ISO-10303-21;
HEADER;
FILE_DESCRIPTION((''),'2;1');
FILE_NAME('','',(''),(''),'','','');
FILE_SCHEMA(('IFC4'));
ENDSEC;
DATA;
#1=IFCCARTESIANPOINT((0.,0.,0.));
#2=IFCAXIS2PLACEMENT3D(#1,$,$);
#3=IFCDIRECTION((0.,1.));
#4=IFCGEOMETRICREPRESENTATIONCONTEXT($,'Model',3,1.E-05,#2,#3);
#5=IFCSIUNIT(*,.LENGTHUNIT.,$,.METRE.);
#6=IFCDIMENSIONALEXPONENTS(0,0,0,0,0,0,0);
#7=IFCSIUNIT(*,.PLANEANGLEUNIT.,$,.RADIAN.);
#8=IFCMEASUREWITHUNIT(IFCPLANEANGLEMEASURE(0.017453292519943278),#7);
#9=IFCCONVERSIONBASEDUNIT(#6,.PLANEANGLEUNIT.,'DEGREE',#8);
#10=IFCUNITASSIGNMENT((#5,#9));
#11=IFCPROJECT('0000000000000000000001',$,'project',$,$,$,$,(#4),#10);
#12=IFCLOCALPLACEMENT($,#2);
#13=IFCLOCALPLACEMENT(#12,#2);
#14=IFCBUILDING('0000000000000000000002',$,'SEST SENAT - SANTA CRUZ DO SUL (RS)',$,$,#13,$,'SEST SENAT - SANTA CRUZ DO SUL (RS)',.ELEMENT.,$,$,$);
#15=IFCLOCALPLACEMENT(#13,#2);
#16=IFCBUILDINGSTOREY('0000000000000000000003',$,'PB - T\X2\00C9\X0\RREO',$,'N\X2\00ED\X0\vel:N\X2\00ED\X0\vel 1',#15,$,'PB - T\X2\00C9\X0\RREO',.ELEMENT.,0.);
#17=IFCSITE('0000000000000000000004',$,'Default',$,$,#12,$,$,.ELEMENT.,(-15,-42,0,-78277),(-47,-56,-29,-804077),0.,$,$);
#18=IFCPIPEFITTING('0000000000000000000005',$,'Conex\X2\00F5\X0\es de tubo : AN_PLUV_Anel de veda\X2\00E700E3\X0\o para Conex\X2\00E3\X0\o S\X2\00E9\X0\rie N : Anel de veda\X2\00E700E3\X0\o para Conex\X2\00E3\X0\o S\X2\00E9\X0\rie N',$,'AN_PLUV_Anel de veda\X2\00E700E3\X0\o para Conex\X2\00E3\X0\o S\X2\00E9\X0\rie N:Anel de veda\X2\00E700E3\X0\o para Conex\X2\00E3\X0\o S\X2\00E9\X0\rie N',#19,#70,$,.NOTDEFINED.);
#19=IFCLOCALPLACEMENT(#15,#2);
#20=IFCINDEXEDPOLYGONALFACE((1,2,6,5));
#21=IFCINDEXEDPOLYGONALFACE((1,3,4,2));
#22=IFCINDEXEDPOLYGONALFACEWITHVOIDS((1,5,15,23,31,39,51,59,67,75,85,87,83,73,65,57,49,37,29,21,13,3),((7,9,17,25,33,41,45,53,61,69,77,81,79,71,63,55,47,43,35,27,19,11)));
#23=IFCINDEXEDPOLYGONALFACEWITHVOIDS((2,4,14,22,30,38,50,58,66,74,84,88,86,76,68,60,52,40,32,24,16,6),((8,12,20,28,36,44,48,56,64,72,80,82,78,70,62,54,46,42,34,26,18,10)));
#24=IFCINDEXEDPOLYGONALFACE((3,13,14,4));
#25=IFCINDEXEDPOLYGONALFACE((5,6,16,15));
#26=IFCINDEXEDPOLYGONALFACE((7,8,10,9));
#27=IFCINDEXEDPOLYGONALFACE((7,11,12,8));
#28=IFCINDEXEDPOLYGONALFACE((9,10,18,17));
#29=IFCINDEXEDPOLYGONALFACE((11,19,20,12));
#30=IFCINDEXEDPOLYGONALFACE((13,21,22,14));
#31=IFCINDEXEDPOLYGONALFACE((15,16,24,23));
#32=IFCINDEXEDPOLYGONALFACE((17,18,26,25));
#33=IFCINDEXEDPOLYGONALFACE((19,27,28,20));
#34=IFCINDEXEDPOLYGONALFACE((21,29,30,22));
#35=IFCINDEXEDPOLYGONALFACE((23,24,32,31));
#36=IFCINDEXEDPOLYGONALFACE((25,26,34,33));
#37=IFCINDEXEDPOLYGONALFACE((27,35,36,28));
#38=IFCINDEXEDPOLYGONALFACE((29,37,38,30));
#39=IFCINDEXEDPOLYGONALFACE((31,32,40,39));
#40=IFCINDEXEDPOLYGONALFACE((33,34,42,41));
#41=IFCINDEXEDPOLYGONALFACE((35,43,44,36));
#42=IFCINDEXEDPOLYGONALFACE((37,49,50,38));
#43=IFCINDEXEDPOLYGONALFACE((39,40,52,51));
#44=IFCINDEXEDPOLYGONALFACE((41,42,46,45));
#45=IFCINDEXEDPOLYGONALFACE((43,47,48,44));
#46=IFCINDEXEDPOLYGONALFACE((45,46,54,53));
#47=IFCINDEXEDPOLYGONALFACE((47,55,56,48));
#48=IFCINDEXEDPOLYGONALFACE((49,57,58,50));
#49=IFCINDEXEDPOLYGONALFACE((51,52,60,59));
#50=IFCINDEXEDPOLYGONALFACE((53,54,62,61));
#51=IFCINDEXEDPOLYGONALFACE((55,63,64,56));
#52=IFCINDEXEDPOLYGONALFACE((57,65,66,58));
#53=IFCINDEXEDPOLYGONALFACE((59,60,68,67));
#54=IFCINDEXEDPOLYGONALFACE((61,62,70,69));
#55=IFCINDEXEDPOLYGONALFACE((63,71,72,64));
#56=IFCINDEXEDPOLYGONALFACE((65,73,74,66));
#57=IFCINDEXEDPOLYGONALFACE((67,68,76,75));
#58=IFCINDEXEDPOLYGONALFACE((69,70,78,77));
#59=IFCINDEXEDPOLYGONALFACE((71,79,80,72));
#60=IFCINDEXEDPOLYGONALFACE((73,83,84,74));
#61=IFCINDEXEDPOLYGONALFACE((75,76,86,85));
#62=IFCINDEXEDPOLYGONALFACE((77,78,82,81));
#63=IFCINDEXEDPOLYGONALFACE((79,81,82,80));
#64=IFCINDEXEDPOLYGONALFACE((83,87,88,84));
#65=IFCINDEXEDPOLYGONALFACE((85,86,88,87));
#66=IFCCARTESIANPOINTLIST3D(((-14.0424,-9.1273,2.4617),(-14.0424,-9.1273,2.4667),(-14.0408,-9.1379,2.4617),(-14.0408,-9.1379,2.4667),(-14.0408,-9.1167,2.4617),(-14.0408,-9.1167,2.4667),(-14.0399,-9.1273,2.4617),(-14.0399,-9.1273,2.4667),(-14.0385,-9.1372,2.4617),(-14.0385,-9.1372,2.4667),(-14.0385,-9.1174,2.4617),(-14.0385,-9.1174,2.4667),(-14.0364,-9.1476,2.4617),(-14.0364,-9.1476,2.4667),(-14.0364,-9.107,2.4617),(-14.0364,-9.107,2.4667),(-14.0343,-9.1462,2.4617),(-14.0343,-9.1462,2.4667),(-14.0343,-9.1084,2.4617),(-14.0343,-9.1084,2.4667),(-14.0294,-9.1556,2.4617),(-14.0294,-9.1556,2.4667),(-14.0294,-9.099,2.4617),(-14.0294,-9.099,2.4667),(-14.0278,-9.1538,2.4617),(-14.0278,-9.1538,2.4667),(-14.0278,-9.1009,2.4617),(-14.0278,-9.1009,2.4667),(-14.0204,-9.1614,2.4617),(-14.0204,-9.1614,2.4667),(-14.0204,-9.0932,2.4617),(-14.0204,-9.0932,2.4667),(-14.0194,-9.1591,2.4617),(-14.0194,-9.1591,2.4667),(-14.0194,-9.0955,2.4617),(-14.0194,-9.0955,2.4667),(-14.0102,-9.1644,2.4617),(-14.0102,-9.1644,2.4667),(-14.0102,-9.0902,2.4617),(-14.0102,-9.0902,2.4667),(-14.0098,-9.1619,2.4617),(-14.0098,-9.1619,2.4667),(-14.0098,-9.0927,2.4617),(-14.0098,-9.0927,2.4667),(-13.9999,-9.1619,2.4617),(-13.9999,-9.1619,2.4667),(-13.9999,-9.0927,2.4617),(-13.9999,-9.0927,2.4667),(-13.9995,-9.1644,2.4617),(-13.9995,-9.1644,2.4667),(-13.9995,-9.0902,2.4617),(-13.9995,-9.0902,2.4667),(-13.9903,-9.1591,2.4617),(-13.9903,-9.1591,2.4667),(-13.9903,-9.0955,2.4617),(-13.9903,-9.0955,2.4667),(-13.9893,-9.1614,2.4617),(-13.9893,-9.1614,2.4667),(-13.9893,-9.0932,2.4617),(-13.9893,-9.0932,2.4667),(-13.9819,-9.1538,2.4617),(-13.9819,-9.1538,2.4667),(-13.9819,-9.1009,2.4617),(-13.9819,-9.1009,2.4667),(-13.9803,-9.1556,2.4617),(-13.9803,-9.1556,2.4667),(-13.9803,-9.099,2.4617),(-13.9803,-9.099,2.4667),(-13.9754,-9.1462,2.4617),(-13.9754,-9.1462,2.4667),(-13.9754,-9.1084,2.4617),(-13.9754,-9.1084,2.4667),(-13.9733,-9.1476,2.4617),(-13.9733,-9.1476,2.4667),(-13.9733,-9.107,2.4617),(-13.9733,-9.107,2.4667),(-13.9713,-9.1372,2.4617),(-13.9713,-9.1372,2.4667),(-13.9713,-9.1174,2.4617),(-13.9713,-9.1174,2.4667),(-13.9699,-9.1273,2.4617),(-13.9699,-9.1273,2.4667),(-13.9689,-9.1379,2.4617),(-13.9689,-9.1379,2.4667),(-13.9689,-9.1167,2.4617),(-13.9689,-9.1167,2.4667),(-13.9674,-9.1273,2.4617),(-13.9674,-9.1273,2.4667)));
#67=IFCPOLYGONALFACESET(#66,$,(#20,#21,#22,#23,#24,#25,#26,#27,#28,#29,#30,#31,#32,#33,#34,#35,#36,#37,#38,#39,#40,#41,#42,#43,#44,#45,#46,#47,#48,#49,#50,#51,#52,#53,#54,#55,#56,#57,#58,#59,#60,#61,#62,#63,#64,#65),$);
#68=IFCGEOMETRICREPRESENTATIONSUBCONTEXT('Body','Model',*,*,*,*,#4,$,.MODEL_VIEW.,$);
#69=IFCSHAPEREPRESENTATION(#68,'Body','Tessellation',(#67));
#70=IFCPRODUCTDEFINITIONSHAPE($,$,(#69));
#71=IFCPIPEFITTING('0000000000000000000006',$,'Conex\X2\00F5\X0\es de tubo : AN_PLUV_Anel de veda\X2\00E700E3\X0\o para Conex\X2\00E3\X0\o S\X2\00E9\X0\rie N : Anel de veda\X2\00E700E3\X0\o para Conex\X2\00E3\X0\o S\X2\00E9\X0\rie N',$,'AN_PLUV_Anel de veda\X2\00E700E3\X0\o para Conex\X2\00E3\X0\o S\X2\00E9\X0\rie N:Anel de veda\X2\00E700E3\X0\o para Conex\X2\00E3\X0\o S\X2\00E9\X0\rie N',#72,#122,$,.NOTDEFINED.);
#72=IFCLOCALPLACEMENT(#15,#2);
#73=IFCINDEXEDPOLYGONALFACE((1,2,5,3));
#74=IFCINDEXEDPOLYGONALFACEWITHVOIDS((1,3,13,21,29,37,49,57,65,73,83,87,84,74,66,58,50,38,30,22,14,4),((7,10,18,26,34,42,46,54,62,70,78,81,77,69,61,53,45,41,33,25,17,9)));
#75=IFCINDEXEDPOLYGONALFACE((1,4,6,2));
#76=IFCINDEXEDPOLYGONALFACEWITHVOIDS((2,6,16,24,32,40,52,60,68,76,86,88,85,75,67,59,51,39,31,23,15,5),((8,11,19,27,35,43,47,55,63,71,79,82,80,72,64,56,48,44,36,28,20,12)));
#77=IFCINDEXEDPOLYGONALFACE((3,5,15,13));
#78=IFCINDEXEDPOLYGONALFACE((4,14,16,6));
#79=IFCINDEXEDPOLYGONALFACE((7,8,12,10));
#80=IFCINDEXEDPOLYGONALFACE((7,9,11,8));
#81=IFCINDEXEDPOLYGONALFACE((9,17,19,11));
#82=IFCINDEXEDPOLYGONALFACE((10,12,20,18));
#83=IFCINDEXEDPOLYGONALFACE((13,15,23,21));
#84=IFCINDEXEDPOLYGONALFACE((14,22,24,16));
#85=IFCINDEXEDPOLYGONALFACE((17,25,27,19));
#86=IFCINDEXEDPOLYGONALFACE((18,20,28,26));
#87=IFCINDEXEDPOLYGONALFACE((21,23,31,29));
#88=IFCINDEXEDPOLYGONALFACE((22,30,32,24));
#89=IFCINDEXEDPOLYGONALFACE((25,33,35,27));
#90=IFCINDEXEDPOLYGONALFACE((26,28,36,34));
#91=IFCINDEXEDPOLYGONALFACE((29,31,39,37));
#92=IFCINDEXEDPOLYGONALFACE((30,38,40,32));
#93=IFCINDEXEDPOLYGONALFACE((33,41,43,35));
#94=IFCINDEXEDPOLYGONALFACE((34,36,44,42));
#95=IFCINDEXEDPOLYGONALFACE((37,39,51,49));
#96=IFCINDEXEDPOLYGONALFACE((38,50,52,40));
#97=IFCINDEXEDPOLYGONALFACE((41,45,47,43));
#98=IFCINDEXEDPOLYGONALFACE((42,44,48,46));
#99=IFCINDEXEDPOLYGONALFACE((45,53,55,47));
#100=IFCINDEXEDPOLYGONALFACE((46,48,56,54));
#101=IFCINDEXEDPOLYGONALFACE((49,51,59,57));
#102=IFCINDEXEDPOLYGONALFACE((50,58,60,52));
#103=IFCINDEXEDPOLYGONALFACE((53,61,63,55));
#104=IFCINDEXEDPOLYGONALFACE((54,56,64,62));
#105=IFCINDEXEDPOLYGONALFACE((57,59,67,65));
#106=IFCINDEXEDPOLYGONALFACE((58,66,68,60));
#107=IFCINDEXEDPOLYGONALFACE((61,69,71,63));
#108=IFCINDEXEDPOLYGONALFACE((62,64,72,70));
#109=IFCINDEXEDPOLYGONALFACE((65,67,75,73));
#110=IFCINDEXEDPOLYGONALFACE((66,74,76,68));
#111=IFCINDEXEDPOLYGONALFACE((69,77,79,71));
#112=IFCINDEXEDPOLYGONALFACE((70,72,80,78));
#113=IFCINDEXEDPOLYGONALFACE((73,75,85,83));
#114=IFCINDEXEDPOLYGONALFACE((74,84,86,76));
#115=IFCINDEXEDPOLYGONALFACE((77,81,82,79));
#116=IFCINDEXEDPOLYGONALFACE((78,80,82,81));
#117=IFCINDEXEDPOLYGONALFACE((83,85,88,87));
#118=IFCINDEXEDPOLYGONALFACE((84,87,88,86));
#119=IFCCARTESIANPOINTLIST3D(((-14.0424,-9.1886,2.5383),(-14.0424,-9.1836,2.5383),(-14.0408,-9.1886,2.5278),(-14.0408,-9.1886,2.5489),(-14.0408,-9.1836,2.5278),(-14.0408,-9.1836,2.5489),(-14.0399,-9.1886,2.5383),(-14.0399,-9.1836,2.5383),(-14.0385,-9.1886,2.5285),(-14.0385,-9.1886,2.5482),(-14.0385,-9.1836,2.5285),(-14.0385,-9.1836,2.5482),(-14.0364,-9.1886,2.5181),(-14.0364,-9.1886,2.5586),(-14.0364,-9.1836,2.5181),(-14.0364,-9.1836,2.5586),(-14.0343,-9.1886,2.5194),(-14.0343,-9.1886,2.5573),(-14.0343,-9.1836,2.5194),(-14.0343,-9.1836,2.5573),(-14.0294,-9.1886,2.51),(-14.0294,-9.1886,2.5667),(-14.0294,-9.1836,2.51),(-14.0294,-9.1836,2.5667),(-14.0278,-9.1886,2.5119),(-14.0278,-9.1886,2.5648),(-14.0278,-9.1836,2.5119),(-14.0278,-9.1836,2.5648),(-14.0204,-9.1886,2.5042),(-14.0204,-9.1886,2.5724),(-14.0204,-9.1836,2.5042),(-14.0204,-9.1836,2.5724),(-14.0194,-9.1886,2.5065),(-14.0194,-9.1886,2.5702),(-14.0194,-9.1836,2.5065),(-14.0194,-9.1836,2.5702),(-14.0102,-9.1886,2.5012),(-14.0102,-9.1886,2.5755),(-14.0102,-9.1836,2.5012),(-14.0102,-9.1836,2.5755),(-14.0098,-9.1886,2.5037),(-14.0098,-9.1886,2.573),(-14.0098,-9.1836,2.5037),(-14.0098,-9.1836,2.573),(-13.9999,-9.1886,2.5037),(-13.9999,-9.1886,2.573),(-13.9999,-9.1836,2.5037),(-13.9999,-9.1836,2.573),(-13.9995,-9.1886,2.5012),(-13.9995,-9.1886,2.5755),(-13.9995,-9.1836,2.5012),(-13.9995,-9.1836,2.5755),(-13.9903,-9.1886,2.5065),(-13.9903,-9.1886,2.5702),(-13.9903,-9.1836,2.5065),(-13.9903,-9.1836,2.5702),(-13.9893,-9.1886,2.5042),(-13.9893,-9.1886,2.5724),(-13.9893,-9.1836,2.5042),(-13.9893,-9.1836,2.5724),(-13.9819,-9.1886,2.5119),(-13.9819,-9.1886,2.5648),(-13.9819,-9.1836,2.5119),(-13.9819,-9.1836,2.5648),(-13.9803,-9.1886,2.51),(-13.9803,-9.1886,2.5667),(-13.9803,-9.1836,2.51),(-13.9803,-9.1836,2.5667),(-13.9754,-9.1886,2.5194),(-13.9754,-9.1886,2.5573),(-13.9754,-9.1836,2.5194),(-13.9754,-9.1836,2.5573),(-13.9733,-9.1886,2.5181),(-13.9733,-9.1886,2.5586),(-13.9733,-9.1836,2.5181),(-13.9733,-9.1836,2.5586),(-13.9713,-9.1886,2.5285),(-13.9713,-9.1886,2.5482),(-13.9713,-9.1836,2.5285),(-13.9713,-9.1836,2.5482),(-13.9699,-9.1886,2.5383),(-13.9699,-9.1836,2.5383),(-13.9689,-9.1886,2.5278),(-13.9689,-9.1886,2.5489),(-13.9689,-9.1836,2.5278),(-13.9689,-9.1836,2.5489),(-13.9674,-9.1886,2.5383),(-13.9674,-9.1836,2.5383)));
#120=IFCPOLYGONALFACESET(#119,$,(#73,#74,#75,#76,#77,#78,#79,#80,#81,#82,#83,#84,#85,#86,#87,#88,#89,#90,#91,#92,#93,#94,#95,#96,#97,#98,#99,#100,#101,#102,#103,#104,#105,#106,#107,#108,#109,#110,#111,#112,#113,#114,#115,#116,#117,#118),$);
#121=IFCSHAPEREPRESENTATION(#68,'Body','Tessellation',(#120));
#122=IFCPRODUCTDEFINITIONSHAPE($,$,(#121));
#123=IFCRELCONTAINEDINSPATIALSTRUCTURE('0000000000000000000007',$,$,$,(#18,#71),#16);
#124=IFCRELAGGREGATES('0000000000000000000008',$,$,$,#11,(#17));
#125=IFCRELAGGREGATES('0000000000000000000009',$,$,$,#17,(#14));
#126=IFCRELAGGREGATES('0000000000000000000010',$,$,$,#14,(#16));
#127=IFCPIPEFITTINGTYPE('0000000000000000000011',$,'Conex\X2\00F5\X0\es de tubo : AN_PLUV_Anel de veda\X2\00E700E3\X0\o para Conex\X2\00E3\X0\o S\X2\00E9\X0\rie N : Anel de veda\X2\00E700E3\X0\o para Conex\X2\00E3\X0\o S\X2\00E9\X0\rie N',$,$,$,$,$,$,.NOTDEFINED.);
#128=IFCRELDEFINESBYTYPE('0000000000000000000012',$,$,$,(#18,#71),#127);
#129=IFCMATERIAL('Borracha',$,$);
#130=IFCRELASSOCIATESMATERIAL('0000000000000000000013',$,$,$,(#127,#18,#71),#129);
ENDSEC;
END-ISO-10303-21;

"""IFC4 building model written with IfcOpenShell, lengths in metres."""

from ifc_helpers import new_model, entity, si_unit, converted_unit, direction, frame, origin, place, context, subcontext, project, spatial, arc, indexed_curve, outline, extrude, source, transform, mapped, material, type_object, type_shapes, element, save


model = new_model("IFC4")

# Units and contexts
model_context = context("Model", 3, precision=1e-05, world=origin(), true_north=direction((0.0, 1.0)))
body_context = subcontext(model_context, "Body", "Model", "MODEL_VIEW")
ifc_project = project(units=[si_unit("LENGTHUNIT", "METRE"), converted_unit("PLANEANGLEUNIT", "DEGREE", entity("IfcPlaneAngleMeasure", 0.017453292519943278), si_unit("PLANEANGLEUNIT", "RADIAN"), dimensions=[0, 0, 0, 0, 0, 0, 0])], contexts=[model_context])

# Site, building, storey
site_placement = place(None, origin())
site = spatial("IfcSite", under=ifc_project, at=site_placement, Name="Default", CompositionType="ELEMENT", RefLatitude=(-15, -42, 0, -78277), RefLongitude=(-47, -56, -29, -804077), RefElevation=0.0)
building_placement = place(site_placement, origin())
building = spatial("IfcBuilding", under=site, at=building_placement, Name="SEST SENAT - SANTA CRUZ DO SUL (RS)", LongName="SEST SENAT - SANTA CRUZ DO SUL (RS)", CompositionType="ELEMENT")
storey_placement = place(building_placement, origin())
storey = spatial("IfcBuildingStorey", under=building, at=storey_placement, Name="PB - TÉRREO", ObjectType="Nível:Nível 1", LongName="PB - TÉRREO", CompositionType="ELEMENT", Elevation=0.0)

# Pipe fittings
ifc_material = material(Name="Borracha")
pipe_fitting_type = type_object("IfcPipeFittingType", Name="Conexões de tubo : AN_PLUV_Anel de vedação para Conexão Série N : Anel de vedação para Conexão Série N", PredefinedType="NOTDEFINED", material=ifc_material)
shared_shape = source(origin(), body_context, "Body", "SweptSolid", [
    extrude(outline(indexed_curve([(-0.0375, 0.0), (0.0, -0.0375), (0.0375, 0.0), (0.0, 0.0375)], segments=[arc(1, 2, 3), arc(3, 4, 1)], self_intersect=False), holes=[indexed_curve([(-0.035, 0.0), (0.0, 0.035), (0.035, 0.0), (0.0, -0.035)], segments=[arc(1, 2, 3), arc(3, 4, 1)], self_intersect=False)]), frame((0.0, 0.0, -0.005)), (0.0, 0.0, 1.0), 0.005),
])
type_shapes(pipe_fitting_type, [shared_shape])
for number, where, z_axis, x_axis, name in (
    (1, (-14.0049, -9.1273, 2.4617), (0.0, 0.0, -1.0), (1.0, 0.0, 0.0), "Conexões de tubo : AN_PLUV_Anel de vedação para Conexão Série N : Anel de vedação para Conexão Série N"),
    (2, (-14.0049, -9.1836, 2.5383), (0.0, 1.0, 0.0), (1.0, 0.0, 0.0), "Conexões de tubo : AN_PLUV_Anel de vedação para Conexão Série N : Anel de vedação para Conexão Série N"),
):
    element("IfcPipeFitting", number, at=place(storey_placement, frame(where, z_axis=z_axis, x_axis=x_axis)), inside=storey, type_object=pipe_fitting_type, material=ifc_material, Name=name, ObjectType="AN_PLUV_Anel de vedação para Conexão Série N:Anel de vedação para Conexão Série N", PredefinedType="NOTDEFINED", context=body_context, shape_type="MappedRepresentation", body=[
        mapped(shared_shape, transform((0.0, 0.0, 0.0), scale=1.0)),
    ])

save(model, "model.ifc")
